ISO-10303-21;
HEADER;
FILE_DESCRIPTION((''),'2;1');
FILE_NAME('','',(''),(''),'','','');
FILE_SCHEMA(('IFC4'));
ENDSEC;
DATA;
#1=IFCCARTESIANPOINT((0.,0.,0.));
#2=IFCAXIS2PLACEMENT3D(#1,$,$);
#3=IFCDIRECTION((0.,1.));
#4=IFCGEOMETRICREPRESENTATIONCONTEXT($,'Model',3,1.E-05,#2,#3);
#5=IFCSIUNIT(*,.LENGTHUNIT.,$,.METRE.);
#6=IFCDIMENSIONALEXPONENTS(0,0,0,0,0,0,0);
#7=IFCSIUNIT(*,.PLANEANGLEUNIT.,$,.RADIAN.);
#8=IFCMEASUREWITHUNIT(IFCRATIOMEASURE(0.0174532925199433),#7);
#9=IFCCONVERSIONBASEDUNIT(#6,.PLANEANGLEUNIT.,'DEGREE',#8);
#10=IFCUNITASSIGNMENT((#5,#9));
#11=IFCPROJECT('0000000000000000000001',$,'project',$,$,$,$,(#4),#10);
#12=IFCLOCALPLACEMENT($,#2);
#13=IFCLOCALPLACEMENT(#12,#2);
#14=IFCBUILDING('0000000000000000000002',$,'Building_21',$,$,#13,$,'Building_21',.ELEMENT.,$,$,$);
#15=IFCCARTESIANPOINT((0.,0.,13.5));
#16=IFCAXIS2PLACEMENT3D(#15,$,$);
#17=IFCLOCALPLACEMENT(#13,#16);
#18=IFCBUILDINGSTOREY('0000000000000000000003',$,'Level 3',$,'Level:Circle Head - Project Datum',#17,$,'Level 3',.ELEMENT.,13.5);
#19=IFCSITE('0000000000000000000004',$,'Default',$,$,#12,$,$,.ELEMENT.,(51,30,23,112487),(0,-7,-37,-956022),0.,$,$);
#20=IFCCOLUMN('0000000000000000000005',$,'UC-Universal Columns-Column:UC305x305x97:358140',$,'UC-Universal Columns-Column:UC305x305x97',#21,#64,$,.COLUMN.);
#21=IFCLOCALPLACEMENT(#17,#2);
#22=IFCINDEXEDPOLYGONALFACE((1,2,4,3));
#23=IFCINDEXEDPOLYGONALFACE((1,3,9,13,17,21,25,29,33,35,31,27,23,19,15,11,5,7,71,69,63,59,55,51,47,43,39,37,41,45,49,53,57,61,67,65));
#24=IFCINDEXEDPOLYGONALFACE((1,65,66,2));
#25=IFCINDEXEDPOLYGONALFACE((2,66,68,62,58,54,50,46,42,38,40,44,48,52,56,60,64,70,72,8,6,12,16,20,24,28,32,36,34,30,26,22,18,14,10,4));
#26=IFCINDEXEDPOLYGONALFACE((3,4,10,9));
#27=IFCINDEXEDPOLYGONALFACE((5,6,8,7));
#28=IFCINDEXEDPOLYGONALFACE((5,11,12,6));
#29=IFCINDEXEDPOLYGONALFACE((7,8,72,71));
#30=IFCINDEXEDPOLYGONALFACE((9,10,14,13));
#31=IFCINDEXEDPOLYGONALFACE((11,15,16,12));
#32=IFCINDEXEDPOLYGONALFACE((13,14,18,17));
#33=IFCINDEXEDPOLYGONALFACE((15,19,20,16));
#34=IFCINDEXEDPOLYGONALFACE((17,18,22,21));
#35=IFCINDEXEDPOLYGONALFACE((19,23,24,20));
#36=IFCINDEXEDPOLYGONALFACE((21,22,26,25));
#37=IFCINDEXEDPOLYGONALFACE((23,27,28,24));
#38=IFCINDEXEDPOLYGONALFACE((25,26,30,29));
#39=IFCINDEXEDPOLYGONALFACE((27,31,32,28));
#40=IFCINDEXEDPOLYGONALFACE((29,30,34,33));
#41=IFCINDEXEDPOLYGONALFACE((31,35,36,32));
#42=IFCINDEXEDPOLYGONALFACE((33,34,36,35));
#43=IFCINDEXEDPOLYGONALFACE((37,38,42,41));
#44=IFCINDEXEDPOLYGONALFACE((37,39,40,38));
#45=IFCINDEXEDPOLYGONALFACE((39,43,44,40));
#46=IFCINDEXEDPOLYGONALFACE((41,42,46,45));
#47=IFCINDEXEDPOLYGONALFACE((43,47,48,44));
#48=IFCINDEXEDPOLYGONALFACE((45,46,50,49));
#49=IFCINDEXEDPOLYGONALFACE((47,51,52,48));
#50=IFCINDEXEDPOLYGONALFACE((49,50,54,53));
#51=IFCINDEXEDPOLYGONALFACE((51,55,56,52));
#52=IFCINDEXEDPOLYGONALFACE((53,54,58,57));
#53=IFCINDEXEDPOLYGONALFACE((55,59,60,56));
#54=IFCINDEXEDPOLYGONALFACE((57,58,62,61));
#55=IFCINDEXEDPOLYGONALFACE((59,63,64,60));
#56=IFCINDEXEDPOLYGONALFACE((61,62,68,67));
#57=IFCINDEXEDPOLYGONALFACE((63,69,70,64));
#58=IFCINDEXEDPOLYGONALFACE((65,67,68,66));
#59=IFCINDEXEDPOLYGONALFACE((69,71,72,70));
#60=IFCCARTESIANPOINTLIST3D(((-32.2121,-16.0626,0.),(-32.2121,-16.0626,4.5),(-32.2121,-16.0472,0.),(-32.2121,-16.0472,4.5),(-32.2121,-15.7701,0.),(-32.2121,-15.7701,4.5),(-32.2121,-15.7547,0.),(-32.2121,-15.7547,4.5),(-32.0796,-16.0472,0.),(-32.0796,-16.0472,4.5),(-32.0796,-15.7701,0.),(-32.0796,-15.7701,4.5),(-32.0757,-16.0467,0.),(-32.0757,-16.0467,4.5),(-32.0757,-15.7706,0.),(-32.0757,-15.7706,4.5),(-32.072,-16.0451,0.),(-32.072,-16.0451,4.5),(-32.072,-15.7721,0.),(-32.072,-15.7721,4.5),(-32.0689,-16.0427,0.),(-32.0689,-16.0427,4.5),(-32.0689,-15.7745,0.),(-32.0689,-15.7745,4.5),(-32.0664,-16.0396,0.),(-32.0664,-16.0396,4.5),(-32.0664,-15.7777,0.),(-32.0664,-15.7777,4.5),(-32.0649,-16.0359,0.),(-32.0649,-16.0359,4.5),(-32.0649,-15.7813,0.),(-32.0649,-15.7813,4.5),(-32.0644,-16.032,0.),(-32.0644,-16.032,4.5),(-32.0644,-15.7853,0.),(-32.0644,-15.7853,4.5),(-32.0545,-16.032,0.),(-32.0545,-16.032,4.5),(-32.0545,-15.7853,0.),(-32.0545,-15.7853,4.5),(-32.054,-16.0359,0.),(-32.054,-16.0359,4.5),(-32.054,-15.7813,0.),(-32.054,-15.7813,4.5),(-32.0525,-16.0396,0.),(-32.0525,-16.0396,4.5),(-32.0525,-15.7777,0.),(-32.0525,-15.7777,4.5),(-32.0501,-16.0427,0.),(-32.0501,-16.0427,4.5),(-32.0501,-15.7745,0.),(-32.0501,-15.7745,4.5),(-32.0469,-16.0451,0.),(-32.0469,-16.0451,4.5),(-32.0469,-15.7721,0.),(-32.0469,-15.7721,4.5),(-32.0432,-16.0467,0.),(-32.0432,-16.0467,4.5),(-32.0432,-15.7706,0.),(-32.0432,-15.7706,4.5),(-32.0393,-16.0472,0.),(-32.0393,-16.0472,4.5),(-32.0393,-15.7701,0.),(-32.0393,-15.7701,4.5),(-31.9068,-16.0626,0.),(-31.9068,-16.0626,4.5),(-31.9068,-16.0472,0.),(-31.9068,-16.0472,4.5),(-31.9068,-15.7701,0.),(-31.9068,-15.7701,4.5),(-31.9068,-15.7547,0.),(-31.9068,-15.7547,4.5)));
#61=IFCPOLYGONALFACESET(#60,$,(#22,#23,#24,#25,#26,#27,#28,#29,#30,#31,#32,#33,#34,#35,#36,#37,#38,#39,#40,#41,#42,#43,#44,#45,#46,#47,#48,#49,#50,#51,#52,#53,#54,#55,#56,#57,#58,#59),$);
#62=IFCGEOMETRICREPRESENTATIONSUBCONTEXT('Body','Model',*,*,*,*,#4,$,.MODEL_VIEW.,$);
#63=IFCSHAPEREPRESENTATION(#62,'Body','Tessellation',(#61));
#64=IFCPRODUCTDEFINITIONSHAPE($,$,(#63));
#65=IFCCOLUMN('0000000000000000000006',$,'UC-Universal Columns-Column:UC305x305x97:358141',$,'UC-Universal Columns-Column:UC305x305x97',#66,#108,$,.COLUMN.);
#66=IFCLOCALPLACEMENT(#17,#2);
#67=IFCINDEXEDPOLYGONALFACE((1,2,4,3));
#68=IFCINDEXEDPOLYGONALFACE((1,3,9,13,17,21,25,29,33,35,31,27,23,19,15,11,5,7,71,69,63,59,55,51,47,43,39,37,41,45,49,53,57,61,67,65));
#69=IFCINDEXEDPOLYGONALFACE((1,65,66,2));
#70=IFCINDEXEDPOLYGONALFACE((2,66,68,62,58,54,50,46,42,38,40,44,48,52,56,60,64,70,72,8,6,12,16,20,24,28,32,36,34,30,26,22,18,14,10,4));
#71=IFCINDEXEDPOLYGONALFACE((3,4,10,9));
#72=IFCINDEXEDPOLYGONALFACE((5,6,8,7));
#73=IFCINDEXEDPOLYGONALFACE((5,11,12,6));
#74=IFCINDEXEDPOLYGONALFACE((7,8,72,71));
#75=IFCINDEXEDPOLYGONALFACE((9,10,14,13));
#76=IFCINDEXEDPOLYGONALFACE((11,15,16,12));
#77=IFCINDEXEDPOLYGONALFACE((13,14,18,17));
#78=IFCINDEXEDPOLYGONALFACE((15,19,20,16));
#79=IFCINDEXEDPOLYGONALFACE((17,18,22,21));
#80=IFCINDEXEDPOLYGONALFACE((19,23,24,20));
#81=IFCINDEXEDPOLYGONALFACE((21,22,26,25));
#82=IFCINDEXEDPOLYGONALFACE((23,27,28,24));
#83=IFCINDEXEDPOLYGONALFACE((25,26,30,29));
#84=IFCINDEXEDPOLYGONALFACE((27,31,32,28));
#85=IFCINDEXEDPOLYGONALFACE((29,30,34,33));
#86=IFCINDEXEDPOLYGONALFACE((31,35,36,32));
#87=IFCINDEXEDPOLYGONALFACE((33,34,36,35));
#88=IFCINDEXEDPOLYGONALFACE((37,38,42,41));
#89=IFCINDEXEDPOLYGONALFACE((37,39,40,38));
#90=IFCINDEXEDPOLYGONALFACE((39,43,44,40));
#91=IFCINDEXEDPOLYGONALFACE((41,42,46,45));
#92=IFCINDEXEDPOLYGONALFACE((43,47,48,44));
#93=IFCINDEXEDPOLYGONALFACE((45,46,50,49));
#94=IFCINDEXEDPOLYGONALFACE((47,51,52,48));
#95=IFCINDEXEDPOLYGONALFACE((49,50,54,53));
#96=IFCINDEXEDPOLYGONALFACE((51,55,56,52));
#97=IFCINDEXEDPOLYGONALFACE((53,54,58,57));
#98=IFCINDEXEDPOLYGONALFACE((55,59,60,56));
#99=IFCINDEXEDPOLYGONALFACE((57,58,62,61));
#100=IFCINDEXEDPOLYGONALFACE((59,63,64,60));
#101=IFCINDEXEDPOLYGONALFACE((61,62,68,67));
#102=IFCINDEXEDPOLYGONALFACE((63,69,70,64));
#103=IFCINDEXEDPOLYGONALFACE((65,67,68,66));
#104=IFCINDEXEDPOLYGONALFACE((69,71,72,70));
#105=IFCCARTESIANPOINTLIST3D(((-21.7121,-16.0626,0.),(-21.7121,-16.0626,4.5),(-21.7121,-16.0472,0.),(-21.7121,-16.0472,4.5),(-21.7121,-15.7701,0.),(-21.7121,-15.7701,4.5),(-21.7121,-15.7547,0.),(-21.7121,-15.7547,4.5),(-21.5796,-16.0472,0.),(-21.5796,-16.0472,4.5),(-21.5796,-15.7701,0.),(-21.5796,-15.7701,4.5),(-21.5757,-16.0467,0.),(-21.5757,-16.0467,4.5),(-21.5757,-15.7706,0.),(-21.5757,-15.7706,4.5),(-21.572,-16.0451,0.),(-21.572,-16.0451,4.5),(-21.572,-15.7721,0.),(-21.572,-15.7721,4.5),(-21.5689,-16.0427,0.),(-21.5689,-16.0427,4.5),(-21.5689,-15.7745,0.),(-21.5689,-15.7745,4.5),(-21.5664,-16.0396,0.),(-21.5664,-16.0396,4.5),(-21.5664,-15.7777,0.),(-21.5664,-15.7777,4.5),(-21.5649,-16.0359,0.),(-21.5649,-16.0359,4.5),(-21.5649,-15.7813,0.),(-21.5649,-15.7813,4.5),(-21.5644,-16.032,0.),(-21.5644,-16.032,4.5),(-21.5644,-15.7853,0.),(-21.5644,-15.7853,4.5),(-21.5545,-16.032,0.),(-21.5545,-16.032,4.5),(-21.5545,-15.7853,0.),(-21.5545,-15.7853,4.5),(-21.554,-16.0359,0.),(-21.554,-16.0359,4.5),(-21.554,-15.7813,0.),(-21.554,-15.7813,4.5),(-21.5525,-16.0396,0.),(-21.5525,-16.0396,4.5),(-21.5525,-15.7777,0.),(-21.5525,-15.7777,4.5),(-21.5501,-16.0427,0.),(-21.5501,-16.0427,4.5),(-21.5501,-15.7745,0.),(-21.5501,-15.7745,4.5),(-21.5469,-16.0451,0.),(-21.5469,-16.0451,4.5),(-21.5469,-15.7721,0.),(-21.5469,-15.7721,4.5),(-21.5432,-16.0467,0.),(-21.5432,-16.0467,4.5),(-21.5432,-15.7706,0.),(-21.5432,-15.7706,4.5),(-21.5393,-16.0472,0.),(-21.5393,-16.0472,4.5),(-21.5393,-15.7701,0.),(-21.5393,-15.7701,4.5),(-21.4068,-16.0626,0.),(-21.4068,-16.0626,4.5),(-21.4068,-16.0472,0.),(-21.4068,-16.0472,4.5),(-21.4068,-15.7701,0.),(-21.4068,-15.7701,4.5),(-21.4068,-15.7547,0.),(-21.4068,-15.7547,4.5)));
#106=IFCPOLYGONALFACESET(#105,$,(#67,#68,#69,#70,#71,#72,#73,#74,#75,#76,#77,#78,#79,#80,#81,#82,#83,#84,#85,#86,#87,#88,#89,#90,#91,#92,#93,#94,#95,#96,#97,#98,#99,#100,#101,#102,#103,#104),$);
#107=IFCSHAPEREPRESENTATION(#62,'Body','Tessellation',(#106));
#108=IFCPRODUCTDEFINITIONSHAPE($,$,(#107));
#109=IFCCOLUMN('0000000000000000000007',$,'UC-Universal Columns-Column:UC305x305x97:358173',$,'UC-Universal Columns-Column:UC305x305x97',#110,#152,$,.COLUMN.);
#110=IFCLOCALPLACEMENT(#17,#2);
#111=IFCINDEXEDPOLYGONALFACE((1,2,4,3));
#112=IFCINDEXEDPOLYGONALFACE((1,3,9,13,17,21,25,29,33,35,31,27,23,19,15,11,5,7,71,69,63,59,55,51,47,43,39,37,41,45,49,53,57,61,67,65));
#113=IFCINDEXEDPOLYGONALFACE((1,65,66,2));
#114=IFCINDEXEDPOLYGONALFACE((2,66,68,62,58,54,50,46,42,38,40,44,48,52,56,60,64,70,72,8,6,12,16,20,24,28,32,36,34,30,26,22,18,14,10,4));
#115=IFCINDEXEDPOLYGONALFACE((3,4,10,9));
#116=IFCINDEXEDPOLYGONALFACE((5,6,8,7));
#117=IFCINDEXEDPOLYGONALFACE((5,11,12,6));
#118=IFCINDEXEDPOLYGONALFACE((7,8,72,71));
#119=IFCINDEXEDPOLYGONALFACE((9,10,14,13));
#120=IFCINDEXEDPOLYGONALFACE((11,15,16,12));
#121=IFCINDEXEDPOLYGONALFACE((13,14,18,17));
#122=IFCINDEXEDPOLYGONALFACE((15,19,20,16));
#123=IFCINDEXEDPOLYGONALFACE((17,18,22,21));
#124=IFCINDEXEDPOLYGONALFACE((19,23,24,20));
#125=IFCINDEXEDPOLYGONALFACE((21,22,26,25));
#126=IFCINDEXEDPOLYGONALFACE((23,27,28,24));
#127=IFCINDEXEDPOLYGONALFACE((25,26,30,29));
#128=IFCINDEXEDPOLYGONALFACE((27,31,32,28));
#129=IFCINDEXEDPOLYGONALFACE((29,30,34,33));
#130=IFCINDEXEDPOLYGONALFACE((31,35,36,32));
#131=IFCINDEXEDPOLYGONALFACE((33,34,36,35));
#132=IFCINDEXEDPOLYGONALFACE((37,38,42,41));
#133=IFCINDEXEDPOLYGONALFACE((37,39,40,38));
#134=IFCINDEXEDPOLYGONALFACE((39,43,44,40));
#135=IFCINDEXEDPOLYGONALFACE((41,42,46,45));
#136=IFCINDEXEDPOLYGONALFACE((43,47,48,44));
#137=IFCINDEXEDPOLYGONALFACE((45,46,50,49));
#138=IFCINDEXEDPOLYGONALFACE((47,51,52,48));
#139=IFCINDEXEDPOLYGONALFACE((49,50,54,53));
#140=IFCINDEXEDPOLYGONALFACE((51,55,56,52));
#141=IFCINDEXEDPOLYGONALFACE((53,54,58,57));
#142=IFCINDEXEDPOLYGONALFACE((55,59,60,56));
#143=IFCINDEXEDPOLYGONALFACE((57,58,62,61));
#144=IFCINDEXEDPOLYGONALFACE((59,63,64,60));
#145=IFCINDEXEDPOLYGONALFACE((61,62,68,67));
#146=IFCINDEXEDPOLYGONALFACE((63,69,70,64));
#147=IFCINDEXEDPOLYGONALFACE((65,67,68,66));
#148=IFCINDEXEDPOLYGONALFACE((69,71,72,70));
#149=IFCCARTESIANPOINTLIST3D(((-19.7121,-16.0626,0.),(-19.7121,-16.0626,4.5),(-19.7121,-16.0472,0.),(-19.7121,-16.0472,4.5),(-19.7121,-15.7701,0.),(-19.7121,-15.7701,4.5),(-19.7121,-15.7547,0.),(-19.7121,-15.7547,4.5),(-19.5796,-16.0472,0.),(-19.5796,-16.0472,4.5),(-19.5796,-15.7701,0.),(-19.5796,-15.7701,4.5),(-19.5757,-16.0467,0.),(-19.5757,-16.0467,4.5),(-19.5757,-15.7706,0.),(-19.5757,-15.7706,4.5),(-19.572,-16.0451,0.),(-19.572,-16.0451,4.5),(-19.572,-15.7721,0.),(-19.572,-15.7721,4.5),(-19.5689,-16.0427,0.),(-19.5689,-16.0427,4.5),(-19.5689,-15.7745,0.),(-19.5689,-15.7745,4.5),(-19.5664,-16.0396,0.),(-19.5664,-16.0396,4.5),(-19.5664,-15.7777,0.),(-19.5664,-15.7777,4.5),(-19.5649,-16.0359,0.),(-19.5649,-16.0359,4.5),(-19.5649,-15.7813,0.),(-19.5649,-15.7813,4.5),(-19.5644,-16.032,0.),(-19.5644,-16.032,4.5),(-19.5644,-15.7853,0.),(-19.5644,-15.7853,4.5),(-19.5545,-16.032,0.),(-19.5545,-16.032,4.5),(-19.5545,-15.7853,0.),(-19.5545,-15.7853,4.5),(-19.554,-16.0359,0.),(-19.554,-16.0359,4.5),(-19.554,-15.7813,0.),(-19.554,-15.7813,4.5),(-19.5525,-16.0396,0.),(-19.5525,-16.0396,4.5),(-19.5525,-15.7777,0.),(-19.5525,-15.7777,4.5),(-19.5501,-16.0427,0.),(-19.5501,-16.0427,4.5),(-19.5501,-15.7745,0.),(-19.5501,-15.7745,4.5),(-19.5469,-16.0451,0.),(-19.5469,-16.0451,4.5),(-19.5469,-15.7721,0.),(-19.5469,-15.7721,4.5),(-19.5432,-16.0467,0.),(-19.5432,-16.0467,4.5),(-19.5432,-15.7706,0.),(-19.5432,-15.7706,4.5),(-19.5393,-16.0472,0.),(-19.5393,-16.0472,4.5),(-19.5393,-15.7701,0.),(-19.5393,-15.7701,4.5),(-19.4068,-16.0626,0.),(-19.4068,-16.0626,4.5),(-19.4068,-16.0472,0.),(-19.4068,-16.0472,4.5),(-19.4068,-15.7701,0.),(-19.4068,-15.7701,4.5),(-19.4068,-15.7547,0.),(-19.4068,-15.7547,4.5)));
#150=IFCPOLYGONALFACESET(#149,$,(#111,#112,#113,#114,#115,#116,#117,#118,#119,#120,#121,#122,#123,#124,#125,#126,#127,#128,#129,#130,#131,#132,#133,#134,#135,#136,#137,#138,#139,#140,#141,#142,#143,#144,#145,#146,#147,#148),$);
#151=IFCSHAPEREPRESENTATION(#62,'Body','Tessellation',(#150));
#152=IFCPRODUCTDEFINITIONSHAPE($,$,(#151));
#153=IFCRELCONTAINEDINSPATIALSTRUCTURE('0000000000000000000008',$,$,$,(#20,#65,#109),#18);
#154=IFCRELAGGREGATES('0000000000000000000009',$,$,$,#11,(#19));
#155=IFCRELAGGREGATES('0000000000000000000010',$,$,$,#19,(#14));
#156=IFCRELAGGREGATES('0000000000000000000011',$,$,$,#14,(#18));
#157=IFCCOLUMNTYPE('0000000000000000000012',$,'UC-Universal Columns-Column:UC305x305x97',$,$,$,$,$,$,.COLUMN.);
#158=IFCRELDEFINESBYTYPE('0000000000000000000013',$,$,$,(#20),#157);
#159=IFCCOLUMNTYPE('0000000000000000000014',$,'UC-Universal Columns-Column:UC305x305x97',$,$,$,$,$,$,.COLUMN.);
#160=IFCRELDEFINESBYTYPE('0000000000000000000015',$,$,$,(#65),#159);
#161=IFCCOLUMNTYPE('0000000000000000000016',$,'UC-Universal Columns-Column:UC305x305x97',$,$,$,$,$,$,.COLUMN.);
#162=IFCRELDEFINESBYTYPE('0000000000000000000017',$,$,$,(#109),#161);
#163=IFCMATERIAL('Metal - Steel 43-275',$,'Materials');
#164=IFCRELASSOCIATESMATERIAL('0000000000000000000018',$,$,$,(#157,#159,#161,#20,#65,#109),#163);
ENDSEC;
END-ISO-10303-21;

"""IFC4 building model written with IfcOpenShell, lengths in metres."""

from ifc_helpers import new_model, entity, si_unit, converted_unit, direction, frame, frame_2d, origin, place, context, subcontext, project, spatial, polyline, circle_curve, parameter, trimmed, segment, composite_curve, i_section, outline, extrude, source, transform, mapped, material, material_profile, profile_set, profile_usage, type_object, type_shapes, element, save


model = new_model("IFC4")

# Units and contexts
model_context = context("Model", 3, precision=1e-05, world=origin(), true_north=direction((0.0, 1.0)))
body_context = subcontext(model_context, "Body", "Model", "MODEL_VIEW")
ifc_project = project(units=[si_unit("LENGTHUNIT", "METRE"), converted_unit("PLANEANGLEUNIT", "DEGREE", entity("IfcRatioMeasure", 0.0174532925199433), si_unit("PLANEANGLEUNIT", "RADIAN"), dimensions=[0, 0, 0, 0, 0, 0, 0])], contexts=[model_context])

# Site, building, storey
site_placement = place(None, origin())
site = spatial("IfcSite", under=ifc_project, at=site_placement, Name="Default", CompositionType="ELEMENT", RefLatitude=(51, 30, 23, 112487), RefLongitude=(0, -7, -37, -956022), RefElevation=0.0)
building_placement = place(site_placement, origin())
building = spatial("IfcBuilding", under=site, at=building_placement, Name="Building_21", LongName="Building_21", CompositionType="ELEMENT")
storey_placement = place(building_placement, frame((0.0, 0.0, 13.5)))
storey = spatial("IfcBuildingStorey", under=building, at=storey_placement, Name="Level 3", ObjectType="Level:Circle Head - Project Datum", LongName="Level 3", CompositionType="ELEMENT", Elevation=13.5)

# Columns
ifc_material_1 = material(Name="Metal - Steel 43-275", Category="Materials")
ifc_material_profile_1 = material_profile(ifc_material_1, outline(composite_curve([segment(polyline([(-0.1527, 0.154, 0.0), (0.1527, 0.154, 0.0)]), True, "CONTINUOUS"), segment(polyline([(0.1527, 0.154, 0.0), (0.1527, 0.1386, 0.0)]), True, "CONTINUOUS"), segment(polyline([(0.1527, 0.1386, 0.0), (0.0201, 0.1386, 0.0)]), True, "CONTINUOUS"), segment(trimmed(circle_curve(frame((0.0201, 0.1234, 0.0)), 0.0152), [parameter(90.0)], [parameter(180.0)], True, "PARAMETER"), True, "CONTINUOUS"), segment(polyline([(0.0049, 0.1234, 0.0), (0.0049, -0.1234, 0.0)]), True, "CONTINUOUS"), segment(trimmed(circle_curve(frame((0.0201, -0.1234, 0.0)), 0.0152), [parameter(180.0)], [parameter(270.0)], True, "PARAMETER"), True, "CONTINUOUS"), segment(polyline([(0.0201, -0.1386, 0.0), (0.1527, -0.1386, 0.0)]), True, "CONTINUOUS"), segment(polyline([(0.1527, -0.1386, 0.0), (0.1527, -0.154, 0.0)]), True, "CONTINUOUS"), segment(polyline([(0.1527, -0.154, 0.0), (-0.1527, -0.154, 0.0)]), True, "CONTINUOUS"), segment(polyline([(-0.1527, -0.154, 0.0), (-0.1527, -0.1386, 0.0)]), True, "CONTINUOUS"), segment(polyline([(-0.1527, -0.1386, 0.0), (-0.0201, -0.1386, 0.0)]), True, "CONTINUOUS"), segment(trimmed(circle_curve(frame((-0.0201, -0.1234, 0.0)), 0.0152), [parameter(270.0)], [parameter(0.0)], True, "PARAMETER"), True, "CONTINUOUS"), segment(polyline([(-0.0049, -0.1234, 0.0), (-0.005, 0.1234, 0.0)]), True, "CONTINUOUS"), segment(trimmed(circle_curve(frame((-0.0201, 0.1234, 0.0)), 0.0152), [parameter(0.0)], [parameter(90.0)], True, "PARAMETER"), True, "CONTINUOUS"), segment(polyline([(-0.0201, 0.1386, 0.0), (-0.1527, 0.1386, 0.0)]), True, "CONTINUOUS"), segment(polyline([(-0.1527, 0.1386, 0.0), (-0.1527, 0.154, 0.0)]), True, "CONTINUOUS")], self_intersect=False), kind="CURVE"), Name="UC305x305x97")
ifc_material_profile_2 = material_profile(ifc_material_1, outline(composite_curve([segment(polyline([(0.1527, 0.154, 0.0), (0.1527, 0.1386, 0.0)]), True, "CONTINUOUS"), segment(polyline([(0.1527, 0.1386, 0.0), (0.0049, 0.1386, 0.0)]), True, "CONTINUOUS"), segment(polyline([(0.0049, 0.1386, 0.0), (0.0049, -0.1386, 0.0)]), True, "CONTINUOUS"), segment(polyline([(0.0049, -0.1386, 0.0), (0.1527, -0.1386, 0.0)]), True, "CONTINUOUS"), segment(polyline([(0.1527, -0.1386, 0.0), (0.1527, -0.154, 0.0)]), True, "CONTINUOUS"), segment(polyline([(0.1527, -0.154, 0.0), (-0.1527, -0.154, 0.0)]), True, "CONTINUOUS"), segment(polyline([(-0.1527, -0.154, 0.0), (-0.1527, -0.1386, 0.0)]), True, "CONTINUOUS"), segment(polyline([(-0.1527, -0.1386, 0.0), (-0.005, -0.1386, 0.0)]), True, "CONTINUOUS"), segment(polyline([(-0.005, -0.1386, 0.0), (-0.005, 0.1386, 0.0)]), True, "CONTINUOUS"), segment(polyline([(-0.005, 0.1386, 0.0), (-0.1527, 0.1386, 0.0)]), True, "CONTINUOUS"), segment(polyline([(-0.1527, 0.1386, 0.0), (-0.1527, 0.154, 0.0)]), True, "CONTINUOUS"), segment(polyline([(-0.1527, 0.154, 0.0), (0.1527, 0.154, 0.0)]), True, "CONTINUOUS")], self_intersect=False), kind="CURVE"), Name="UC305x305x97")
ifc_profile_set = profile_set([ifc_material_profile_1, ifc_material_profile_2], Name="UC305x305x97")
ifc_profile_usage_1 = profile_usage(ifc_profile_set)
column_type_1 = type_object("IfcColumnType", Name="UC-Universal Columns-Column:UC305x305x97", PredefinedType="COLUMN", material=ifc_profile_set)
shared_shape_1 = source(origin(), body_context, "Body", "SweptSolid", [
    extrude(i_section(OverallWidth=0.3053, OverallDepth=0.3079, WebThickness=0.0099, FlangeThickness=0.0154, FilletRadius=0.0152, at=frame_2d((0.0, 0.0), x_axis=(0.0, 1.0))), frame((-32.0595, -15.9086, 13.5), z_axis=(0.0, 0.0, 1.0), x_axis=(0.0, -1.0, 0.0)), (0.0, 0.0, 1.0), 4.5),
])
type_shapes(column_type_1, [shared_shape_1])
column_1_placement = place(storey_placement, frame((0.0, 0.0, -13.5)))
element("IfcColumn", 1, at=column_1_placement, inside=storey, type_object=column_type_1, material=ifc_profile_usage_1, Name="UC-Universal Columns-Column:UC305x305x97:358140", ObjectType="UC-Universal Columns-Column:UC305x305x97", PredefinedType="COLUMN", context=body_context, shape_type="MappedRepresentation", body=[
    mapped(shared_shape_1, transform((0.0, 0.0, 0.0), scale=1.0)),
])
ifc_profile_usage_2 = profile_usage(ifc_profile_set)
column_type_2 = type_object("IfcColumnType", Name="UC-Universal Columns-Column:UC305x305x97", PredefinedType="COLUMN", material=ifc_profile_set)
shared_shape_2 = source(origin(), body_context, "Body", "SweptSolid", [
    extrude(i_section(OverallWidth=0.3053, OverallDepth=0.3079, WebThickness=0.0099, FlangeThickness=0.0154, FilletRadius=0.0152, at=frame_2d((0.0, 0.0), x_axis=(0.0, 1.0))), frame((-21.5595, -15.9086, 13.5), z_axis=(0.0, 0.0, 1.0), x_axis=(0.0, -1.0, 0.0)), (0.0, 0.0, 1.0), 4.5),
])
type_shapes(column_type_2, [shared_shape_2])
column_2_placement = place(storey_placement, frame((0.0, 0.0, -13.5)))
element("IfcColumn", 2, at=column_2_placement, inside=storey, type_object=column_type_2, material=ifc_profile_usage_2, Name="UC-Universal Columns-Column:UC305x305x97:358141", ObjectType="UC-Universal Columns-Column:UC305x305x97", PredefinedType="COLUMN", context=body_context, shape_type="MappedRepresentation", body=[
    mapped(shared_shape_2, transform((0.0, 0.0, 0.0), scale=1.0)),
])
ifc_profile_usage_3 = profile_usage(ifc_profile_set)
column_type_3 = type_object("IfcColumnType", Name="UC-Universal Columns-Column:UC305x305x97", PredefinedType="COLUMN", material=ifc_profile_set)
shared_shape_3 = source(origin(), body_context, "Body", "SweptSolid", [
    extrude(i_section(OverallWidth=0.3053, OverallDepth=0.3079, WebThickness=0.0099, FlangeThickness=0.0154, FilletRadius=0.0152, at=frame_2d((0.0, 0.0), x_axis=(0.0, 1.0))), frame((-19.5595, -15.9086, 13.5), z_axis=(0.0, 0.0, 1.0), x_axis=(0.0, -1.0, 0.0)), (0.0, 0.0, 1.0), 4.5),
])
type_shapes(column_type_3, [shared_shape_3])
column_3_placement = place(storey_placement, frame((0.0, 0.0, -13.5)))
element("IfcColumn", 3, at=column_3_placement, inside=storey, type_object=column_type_3, material=ifc_profile_usage_3, Name="UC-Universal Columns-Column:UC305x305x97:358173", ObjectType="UC-Universal Columns-Column:UC305x305x97", PredefinedType="COLUMN", context=body_context, shape_type="MappedRepresentation", body=[
    mapped(shared_shape_3, transform((0.0, 0.0, 0.0), scale=1.0)),
])

save(model, "model.ifc")
